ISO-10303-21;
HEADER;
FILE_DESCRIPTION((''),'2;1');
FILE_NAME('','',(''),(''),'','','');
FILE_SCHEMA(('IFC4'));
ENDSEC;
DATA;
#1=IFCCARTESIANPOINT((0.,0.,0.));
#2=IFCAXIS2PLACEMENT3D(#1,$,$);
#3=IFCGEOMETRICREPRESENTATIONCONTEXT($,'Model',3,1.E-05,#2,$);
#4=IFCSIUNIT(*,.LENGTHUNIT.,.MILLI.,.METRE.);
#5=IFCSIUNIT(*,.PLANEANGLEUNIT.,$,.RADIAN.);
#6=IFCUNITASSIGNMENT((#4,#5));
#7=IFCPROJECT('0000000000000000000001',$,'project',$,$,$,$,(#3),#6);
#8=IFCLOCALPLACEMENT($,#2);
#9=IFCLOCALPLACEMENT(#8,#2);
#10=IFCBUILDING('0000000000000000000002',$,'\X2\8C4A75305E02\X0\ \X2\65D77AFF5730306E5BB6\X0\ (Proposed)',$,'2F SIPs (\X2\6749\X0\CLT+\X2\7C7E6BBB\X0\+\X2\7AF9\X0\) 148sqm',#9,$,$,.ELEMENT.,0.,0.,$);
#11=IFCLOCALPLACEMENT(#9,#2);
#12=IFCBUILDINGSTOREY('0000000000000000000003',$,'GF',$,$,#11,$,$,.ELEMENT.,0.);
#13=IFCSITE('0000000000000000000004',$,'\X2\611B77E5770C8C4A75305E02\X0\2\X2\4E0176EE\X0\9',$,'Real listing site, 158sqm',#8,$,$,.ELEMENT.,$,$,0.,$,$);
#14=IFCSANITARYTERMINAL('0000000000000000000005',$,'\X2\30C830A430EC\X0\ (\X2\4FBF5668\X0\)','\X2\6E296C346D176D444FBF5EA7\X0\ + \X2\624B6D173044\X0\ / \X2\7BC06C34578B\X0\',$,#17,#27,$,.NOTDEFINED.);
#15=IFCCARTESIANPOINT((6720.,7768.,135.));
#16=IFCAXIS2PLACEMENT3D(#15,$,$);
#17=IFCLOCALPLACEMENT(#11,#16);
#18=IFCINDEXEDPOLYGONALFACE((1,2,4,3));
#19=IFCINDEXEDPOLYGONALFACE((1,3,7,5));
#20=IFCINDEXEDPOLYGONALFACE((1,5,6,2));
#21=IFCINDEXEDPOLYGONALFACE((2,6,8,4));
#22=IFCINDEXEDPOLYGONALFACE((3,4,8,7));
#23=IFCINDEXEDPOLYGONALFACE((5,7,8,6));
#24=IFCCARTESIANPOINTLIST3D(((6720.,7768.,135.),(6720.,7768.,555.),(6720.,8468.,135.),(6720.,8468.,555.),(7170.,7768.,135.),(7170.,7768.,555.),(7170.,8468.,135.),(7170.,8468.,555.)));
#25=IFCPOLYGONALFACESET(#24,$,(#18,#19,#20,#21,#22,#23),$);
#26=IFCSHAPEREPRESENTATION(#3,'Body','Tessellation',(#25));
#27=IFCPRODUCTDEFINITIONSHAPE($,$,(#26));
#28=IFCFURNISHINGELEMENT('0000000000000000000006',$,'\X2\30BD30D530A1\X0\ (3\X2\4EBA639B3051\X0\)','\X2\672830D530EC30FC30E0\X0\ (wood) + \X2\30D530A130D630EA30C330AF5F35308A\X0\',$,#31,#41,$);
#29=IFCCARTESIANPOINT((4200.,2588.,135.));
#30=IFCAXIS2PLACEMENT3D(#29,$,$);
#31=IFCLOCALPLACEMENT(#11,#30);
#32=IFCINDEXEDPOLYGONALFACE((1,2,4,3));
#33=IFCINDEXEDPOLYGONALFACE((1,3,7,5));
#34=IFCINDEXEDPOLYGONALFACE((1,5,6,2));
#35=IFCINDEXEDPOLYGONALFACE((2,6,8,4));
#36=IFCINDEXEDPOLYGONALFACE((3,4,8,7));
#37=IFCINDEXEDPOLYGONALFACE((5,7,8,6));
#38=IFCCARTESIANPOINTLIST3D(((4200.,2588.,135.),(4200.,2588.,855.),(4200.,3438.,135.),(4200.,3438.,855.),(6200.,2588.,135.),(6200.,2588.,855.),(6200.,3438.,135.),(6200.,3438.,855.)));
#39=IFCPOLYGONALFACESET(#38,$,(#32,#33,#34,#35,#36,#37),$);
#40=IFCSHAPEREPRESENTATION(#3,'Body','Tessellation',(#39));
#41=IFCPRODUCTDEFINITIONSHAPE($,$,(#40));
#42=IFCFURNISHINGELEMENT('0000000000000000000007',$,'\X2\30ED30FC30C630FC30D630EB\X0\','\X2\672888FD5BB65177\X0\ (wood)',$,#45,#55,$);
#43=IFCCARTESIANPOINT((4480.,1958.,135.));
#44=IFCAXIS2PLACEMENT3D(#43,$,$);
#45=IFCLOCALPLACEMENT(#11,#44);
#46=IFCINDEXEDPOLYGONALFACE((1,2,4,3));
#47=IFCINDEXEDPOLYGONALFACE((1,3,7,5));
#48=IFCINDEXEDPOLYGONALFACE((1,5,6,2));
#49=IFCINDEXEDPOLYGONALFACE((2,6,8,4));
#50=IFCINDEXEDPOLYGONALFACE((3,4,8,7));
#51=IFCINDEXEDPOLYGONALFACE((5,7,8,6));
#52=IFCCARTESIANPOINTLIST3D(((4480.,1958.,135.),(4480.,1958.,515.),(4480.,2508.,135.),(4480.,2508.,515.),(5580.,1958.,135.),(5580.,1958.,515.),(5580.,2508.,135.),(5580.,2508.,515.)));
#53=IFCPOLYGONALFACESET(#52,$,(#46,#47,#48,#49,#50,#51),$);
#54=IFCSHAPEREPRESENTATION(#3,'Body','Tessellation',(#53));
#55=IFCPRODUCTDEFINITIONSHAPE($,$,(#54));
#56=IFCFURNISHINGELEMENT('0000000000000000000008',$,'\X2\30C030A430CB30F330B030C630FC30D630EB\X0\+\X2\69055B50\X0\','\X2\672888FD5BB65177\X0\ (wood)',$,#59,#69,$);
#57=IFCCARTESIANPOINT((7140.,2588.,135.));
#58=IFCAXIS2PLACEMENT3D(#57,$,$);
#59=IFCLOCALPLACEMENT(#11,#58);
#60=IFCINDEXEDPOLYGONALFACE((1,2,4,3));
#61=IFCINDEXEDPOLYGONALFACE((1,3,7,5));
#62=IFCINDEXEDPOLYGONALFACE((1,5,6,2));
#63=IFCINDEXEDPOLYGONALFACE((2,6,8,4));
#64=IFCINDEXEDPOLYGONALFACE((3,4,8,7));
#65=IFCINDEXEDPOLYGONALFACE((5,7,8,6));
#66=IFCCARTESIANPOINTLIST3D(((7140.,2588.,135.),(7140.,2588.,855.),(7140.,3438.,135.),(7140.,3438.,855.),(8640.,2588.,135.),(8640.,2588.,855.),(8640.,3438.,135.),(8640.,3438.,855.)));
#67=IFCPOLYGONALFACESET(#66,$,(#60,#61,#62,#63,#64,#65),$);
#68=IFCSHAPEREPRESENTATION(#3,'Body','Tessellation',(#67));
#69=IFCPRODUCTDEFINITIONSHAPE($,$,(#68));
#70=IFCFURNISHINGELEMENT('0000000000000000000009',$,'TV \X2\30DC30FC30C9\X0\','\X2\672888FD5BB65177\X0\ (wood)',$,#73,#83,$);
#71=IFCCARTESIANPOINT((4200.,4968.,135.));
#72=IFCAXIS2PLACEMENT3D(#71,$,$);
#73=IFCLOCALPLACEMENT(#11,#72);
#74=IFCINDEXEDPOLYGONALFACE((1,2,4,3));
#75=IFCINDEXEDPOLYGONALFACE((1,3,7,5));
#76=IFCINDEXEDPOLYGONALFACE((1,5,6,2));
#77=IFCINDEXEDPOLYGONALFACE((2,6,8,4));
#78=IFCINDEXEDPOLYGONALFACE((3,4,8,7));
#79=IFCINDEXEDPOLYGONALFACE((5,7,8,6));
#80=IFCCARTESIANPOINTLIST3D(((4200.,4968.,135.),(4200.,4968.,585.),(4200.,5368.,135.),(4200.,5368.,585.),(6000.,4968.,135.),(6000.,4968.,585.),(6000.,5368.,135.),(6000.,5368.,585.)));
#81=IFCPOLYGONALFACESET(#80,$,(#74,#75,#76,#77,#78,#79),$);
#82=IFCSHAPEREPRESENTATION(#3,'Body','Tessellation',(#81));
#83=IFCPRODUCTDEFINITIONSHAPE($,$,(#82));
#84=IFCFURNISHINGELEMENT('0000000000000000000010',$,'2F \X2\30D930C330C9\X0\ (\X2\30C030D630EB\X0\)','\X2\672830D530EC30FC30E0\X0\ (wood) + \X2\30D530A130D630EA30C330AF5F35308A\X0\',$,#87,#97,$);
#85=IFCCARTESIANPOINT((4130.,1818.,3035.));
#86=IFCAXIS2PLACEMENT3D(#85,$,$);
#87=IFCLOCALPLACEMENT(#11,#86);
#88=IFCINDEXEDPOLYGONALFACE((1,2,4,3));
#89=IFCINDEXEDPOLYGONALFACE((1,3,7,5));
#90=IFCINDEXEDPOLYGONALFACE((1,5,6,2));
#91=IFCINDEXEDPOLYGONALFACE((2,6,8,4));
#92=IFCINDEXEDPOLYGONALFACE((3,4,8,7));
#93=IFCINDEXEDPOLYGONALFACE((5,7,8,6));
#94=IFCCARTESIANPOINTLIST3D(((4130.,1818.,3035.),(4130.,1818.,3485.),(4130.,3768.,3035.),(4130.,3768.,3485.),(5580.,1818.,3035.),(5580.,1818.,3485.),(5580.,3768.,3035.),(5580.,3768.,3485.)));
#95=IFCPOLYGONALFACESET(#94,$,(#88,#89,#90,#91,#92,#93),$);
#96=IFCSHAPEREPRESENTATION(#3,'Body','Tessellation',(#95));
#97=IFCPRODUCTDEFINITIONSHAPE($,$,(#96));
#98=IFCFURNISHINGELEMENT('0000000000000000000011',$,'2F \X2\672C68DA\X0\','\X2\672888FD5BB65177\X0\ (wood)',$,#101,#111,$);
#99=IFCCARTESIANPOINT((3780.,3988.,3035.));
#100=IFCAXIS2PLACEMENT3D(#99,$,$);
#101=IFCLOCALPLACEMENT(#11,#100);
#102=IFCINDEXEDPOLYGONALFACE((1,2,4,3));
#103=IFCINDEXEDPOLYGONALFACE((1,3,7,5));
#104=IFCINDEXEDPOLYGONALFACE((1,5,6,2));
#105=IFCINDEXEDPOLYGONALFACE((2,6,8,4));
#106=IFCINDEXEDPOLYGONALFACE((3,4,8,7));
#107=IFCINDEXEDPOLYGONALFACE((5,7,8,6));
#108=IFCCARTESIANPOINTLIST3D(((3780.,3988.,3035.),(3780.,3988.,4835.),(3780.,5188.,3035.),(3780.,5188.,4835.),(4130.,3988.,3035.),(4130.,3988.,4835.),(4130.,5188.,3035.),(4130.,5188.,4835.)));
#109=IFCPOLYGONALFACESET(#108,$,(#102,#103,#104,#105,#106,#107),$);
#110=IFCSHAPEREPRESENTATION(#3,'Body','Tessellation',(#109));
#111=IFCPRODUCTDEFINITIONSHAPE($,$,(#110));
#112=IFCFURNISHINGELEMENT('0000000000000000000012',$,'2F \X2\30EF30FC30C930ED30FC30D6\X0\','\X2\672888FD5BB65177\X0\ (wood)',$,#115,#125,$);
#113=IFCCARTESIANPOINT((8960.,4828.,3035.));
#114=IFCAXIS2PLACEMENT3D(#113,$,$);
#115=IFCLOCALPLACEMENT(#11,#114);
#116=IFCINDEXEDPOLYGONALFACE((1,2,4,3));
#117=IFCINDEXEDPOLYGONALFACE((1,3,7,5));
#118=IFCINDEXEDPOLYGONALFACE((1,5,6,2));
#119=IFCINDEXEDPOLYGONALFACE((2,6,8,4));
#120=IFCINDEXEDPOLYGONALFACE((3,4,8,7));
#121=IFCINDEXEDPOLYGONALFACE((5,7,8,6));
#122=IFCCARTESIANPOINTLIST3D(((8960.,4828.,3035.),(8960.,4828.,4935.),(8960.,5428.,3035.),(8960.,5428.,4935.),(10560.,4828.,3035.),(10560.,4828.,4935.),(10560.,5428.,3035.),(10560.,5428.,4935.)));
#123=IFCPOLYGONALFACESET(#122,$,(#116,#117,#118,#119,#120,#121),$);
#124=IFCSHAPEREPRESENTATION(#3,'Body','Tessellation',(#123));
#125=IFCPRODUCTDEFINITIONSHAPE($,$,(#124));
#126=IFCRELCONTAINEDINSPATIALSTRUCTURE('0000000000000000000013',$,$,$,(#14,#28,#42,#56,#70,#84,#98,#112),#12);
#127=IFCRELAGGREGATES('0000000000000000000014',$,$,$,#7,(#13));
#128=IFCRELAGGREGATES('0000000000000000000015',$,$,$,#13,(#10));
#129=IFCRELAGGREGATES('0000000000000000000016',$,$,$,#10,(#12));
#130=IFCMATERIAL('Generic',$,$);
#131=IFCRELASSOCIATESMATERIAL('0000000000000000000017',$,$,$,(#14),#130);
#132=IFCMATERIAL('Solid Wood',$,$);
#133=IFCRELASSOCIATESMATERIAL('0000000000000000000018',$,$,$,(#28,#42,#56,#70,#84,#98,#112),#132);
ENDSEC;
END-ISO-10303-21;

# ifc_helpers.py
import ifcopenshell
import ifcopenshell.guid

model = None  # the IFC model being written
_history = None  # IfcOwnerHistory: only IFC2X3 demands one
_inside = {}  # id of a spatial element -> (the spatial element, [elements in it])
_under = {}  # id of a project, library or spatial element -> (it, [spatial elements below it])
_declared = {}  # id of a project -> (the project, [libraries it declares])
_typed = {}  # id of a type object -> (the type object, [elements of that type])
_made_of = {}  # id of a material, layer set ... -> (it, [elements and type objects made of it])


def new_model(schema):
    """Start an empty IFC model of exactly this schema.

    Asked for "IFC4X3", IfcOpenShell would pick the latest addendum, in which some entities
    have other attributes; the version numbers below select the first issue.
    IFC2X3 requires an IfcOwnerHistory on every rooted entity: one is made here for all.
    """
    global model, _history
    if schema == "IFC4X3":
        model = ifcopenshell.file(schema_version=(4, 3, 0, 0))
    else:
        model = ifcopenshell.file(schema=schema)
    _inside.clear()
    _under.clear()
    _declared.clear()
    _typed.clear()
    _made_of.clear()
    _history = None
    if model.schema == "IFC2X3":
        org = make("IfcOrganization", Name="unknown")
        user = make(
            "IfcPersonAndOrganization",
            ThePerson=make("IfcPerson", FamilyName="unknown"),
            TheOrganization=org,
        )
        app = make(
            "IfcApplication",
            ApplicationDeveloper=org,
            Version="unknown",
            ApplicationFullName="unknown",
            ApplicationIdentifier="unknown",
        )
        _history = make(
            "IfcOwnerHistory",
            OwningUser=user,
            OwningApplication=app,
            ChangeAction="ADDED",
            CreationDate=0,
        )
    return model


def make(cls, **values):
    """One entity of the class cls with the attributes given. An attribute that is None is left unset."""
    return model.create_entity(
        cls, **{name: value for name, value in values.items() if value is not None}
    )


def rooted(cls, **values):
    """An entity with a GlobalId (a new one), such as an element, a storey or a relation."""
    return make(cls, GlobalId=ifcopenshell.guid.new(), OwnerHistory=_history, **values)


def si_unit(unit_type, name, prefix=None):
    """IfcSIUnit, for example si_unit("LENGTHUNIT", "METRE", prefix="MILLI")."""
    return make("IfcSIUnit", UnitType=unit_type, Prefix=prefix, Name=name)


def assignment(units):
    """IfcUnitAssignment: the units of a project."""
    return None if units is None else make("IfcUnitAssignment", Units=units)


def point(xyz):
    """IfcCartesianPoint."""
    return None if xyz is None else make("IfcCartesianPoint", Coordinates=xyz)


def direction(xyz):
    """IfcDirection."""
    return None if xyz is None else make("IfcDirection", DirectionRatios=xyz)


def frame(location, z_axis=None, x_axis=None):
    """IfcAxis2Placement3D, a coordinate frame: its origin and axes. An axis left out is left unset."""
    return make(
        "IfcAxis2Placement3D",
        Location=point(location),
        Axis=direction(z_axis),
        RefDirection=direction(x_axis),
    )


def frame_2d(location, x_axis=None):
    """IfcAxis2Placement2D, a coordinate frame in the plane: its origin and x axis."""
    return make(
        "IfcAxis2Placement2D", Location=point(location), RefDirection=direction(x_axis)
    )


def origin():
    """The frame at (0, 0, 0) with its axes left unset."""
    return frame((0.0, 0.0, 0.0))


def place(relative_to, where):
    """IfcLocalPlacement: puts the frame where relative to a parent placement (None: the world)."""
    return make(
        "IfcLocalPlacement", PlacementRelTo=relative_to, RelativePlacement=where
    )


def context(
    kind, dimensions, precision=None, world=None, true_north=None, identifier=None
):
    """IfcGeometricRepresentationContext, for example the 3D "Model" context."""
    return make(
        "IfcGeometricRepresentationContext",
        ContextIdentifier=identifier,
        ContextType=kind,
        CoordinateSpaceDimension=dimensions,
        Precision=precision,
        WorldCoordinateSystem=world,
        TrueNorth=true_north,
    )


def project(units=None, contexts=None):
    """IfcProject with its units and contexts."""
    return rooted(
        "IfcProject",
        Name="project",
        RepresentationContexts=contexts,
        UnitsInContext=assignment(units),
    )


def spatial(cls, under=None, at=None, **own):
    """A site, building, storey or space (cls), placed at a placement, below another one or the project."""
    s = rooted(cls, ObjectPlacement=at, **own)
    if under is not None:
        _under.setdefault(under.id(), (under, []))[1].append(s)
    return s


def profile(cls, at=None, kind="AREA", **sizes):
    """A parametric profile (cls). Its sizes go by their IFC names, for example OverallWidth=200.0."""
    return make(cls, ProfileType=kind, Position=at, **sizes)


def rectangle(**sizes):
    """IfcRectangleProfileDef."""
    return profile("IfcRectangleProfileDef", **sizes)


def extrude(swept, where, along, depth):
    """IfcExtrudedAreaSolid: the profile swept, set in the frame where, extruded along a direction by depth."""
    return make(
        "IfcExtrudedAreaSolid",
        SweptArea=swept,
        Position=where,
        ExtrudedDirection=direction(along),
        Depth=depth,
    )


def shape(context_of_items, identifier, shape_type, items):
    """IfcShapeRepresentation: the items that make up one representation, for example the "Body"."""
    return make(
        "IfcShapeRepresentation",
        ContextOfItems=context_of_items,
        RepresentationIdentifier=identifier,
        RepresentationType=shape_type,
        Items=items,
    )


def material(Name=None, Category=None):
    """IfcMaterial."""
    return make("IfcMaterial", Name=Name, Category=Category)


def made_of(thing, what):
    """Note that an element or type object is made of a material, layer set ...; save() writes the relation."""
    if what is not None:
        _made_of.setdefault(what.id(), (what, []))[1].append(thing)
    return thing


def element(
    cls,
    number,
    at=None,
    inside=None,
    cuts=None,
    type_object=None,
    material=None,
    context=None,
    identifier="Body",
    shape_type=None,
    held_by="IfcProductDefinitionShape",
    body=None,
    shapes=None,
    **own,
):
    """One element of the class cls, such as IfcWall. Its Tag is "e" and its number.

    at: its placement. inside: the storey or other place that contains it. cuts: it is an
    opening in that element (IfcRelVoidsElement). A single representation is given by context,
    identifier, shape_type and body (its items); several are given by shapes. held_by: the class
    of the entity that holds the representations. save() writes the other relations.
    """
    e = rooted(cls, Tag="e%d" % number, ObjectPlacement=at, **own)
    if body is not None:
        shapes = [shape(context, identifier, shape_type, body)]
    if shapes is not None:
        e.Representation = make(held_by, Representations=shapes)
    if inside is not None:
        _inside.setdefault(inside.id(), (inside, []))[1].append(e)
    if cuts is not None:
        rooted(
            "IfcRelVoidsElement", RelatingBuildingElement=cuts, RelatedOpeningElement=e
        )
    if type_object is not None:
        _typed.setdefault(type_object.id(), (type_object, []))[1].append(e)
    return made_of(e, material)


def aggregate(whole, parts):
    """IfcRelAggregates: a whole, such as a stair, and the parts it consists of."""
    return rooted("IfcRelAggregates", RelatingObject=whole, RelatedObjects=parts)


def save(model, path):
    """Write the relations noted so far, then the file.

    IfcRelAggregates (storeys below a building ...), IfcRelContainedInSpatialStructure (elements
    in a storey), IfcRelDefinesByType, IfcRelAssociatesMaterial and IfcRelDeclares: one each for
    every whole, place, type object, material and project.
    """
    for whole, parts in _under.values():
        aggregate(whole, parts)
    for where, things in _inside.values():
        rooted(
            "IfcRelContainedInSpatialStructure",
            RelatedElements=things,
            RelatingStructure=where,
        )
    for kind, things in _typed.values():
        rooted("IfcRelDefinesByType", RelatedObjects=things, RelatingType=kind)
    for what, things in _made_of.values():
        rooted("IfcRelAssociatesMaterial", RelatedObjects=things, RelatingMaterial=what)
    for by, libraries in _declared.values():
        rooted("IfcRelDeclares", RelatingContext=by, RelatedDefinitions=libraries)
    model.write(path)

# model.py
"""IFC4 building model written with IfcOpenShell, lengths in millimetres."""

from ifc_helpers import new_model, si_unit, frame, frame_2d, origin, place, context, project, spatial, rectangle, extrude, material, element, save


model = new_model("IFC4")

# Units and contexts
model_context = context("Model", 3, precision=1e-05, world=origin())
ifc_project = project(units=[si_unit("LENGTHUNIT", "METRE", prefix="MILLI"), si_unit("PLANEANGLEUNIT", "RADIAN")], contexts=[model_context])

# Site, building, storey
site_placement = place(None, origin())
site = spatial("IfcSite", under=ifc_project, at=site_placement, Name="愛知県豊田市2丁目9", ObjectType="Real listing site, 158sqm", CompositionType="ELEMENT", RefElevation=0.0)
building_placement = place(site_placement, origin())
building = spatial("IfcBuilding", under=site, at=building_placement, Name="豊田市 旗竿地の家 (Proposed)", ObjectType="2F SIPs (杉CLT+籾殻+竹) 148sqm", CompositionType="ELEMENT", ElevationOfRefHeight=0.0, ElevationOfTerrain=0.0)
storey_placement = place(building_placement, origin())
storey = spatial("IfcBuildingStorey", under=building, at=storey_placement, Name="GF", CompositionType="ELEMENT", Elevation=0.0)

# Shared definitions
ifc_material_1 = material(Name="Solid Wood")

# Shared definitions
ifc_material_2 = material(Name="Generic")

# Sanitary terminal
sanitary_terminal_1_placement = place(storey_placement, frame((6720.0, 7768.0, 135.0)))
element("IfcSanitaryTerminal", 1, at=sanitary_terminal_1_placement, inside=storey, material=ifc_material_2, Name="トイレ (便器)", Description="温水洗浄便座 + 手洗い / 節水型", PredefinedType="NOTDEFINED", context=model_context, shape_type="SweptSolid", body=[
    extrude(rectangle(XDim=450.0, YDim=700.0, at=frame_2d((225.0, 350.0))), frame((6720.0, 7768.0, 135.0)), (0.0, 0.0, 1.0), 420.0),
])

# Furnishing elements
furnishing_1_placement = place(storey_placement, frame((4200.0, 2588.0, 135.0)))
element("IfcFurnishingElement", 2, at=furnishing_1_placement, inside=storey, material=ifc_material_1, Name="ソファ (3人掛け)", Description="木フレーム (wood) + ファブリック張り", context=model_context, shape_type="SweptSolid", body=[
    extrude(rectangle(XDim=2000.0, YDim=850.0, at=frame_2d((1000.0, 425.0))), frame((4200.0, 2588.0, 135.0)), (0.0, 0.0, 1.0), 720.0),
])
furnishing_2_placement = place(storey_placement, frame((4480.0, 1958.0, 135.0)))
element("IfcFurnishingElement", 3, at=furnishing_2_placement, inside=storey, material=ifc_material_1, Name="ローテーブル", Description="木製家具 (wood)", context=model_context, shape_type="SweptSolid", body=[
    extrude(rectangle(XDim=1100.0, YDim=550.0, at=frame_2d((550.0, 275.0))), frame((4480.0, 1958.0, 135.0)), (0.0, 0.0, 1.0), 380.0),
])
furnishing_3_placement = place(storey_placement, frame((7140.0, 2588.0, 135.0)))
element("IfcFurnishingElement", 4, at=furnishing_3_placement, inside=storey, material=ifc_material_1, Name="ダイニングテーブル+椅子", Description="木製家具 (wood)", context=model_context, shape_type="SweptSolid", body=[
    extrude(rectangle(XDim=1500.0, YDim=850.0, at=frame_2d((750.0, 425.0))), frame((7140.0, 2588.0, 135.0)), (0.0, 0.0, 1.0), 720.0),
])
furnishing_4_placement = place(storey_placement, frame((4200.0, 4968.0, 135.0)))
element("IfcFurnishingElement", 5, at=furnishing_4_placement, inside=storey, material=ifc_material_1, Name="TV ボード", Description="木製家具 (wood)", context=model_context, shape_type="SweptSolid", body=[
    extrude(rectangle(XDim=1800.0, YDim=400.0, at=frame_2d((900.0, 200.0))), frame((4200.0, 4968.0, 135.0)), (0.0, 0.0, 1.0), 450.0),
])
furnishing_5_placement = place(storey_placement, frame((4130.0, 1818.0, 3035.0)))
element("IfcFurnishingElement", 6, at=furnishing_5_placement, inside=storey, material=ifc_material_1, Name="2F ベッド (ダブル)", Description="木フレーム (wood) + ファブリック張り", context=model_context, shape_type="SweptSolid", body=[
    extrude(rectangle(XDim=1450.0, YDim=1950.0, at=frame_2d((725.0, 975.0))), frame((4130.0, 1818.0, 3035.0)), (0.0, 0.0, 1.0), 450.0),
])
furnishing_6_placement = place(storey_placement, frame((3780.0, 3988.0, 3035.0)))
element("IfcFurnishingElement", 7, at=furnishing_6_placement, inside=storey, material=ifc_material_1, Name="2F 本棚", Description="木製家具 (wood)", context=model_context, shape_type="SweptSolid", body=[
    extrude(rectangle(XDim=350.0, YDim=1200.0, at=frame_2d((175.0, 600.0))), frame((3780.0, 3988.0, 3035.0)), (0.0, 0.0, 1.0), 1800.0),
])
furnishing_7_placement = place(storey_placement, frame((8960.0, 4828.0, 3035.0)))
element("IfcFurnishingElement", 8, at=furnishing_7_placement, inside=storey, material=ifc_material_1, Name="2F ワードローブ", Description="木製家具 (wood)", context=model_context, shape_type="SweptSolid", body=[
    extrude(rectangle(XDim=1600.0, YDim=600.0, at=frame_2d((800.0, 300.0))), frame((8960.0, 4828.0, 3035.0)), (0.0, 0.0, 1.0), 1900.0),
])

save(model, "model.ifc")
